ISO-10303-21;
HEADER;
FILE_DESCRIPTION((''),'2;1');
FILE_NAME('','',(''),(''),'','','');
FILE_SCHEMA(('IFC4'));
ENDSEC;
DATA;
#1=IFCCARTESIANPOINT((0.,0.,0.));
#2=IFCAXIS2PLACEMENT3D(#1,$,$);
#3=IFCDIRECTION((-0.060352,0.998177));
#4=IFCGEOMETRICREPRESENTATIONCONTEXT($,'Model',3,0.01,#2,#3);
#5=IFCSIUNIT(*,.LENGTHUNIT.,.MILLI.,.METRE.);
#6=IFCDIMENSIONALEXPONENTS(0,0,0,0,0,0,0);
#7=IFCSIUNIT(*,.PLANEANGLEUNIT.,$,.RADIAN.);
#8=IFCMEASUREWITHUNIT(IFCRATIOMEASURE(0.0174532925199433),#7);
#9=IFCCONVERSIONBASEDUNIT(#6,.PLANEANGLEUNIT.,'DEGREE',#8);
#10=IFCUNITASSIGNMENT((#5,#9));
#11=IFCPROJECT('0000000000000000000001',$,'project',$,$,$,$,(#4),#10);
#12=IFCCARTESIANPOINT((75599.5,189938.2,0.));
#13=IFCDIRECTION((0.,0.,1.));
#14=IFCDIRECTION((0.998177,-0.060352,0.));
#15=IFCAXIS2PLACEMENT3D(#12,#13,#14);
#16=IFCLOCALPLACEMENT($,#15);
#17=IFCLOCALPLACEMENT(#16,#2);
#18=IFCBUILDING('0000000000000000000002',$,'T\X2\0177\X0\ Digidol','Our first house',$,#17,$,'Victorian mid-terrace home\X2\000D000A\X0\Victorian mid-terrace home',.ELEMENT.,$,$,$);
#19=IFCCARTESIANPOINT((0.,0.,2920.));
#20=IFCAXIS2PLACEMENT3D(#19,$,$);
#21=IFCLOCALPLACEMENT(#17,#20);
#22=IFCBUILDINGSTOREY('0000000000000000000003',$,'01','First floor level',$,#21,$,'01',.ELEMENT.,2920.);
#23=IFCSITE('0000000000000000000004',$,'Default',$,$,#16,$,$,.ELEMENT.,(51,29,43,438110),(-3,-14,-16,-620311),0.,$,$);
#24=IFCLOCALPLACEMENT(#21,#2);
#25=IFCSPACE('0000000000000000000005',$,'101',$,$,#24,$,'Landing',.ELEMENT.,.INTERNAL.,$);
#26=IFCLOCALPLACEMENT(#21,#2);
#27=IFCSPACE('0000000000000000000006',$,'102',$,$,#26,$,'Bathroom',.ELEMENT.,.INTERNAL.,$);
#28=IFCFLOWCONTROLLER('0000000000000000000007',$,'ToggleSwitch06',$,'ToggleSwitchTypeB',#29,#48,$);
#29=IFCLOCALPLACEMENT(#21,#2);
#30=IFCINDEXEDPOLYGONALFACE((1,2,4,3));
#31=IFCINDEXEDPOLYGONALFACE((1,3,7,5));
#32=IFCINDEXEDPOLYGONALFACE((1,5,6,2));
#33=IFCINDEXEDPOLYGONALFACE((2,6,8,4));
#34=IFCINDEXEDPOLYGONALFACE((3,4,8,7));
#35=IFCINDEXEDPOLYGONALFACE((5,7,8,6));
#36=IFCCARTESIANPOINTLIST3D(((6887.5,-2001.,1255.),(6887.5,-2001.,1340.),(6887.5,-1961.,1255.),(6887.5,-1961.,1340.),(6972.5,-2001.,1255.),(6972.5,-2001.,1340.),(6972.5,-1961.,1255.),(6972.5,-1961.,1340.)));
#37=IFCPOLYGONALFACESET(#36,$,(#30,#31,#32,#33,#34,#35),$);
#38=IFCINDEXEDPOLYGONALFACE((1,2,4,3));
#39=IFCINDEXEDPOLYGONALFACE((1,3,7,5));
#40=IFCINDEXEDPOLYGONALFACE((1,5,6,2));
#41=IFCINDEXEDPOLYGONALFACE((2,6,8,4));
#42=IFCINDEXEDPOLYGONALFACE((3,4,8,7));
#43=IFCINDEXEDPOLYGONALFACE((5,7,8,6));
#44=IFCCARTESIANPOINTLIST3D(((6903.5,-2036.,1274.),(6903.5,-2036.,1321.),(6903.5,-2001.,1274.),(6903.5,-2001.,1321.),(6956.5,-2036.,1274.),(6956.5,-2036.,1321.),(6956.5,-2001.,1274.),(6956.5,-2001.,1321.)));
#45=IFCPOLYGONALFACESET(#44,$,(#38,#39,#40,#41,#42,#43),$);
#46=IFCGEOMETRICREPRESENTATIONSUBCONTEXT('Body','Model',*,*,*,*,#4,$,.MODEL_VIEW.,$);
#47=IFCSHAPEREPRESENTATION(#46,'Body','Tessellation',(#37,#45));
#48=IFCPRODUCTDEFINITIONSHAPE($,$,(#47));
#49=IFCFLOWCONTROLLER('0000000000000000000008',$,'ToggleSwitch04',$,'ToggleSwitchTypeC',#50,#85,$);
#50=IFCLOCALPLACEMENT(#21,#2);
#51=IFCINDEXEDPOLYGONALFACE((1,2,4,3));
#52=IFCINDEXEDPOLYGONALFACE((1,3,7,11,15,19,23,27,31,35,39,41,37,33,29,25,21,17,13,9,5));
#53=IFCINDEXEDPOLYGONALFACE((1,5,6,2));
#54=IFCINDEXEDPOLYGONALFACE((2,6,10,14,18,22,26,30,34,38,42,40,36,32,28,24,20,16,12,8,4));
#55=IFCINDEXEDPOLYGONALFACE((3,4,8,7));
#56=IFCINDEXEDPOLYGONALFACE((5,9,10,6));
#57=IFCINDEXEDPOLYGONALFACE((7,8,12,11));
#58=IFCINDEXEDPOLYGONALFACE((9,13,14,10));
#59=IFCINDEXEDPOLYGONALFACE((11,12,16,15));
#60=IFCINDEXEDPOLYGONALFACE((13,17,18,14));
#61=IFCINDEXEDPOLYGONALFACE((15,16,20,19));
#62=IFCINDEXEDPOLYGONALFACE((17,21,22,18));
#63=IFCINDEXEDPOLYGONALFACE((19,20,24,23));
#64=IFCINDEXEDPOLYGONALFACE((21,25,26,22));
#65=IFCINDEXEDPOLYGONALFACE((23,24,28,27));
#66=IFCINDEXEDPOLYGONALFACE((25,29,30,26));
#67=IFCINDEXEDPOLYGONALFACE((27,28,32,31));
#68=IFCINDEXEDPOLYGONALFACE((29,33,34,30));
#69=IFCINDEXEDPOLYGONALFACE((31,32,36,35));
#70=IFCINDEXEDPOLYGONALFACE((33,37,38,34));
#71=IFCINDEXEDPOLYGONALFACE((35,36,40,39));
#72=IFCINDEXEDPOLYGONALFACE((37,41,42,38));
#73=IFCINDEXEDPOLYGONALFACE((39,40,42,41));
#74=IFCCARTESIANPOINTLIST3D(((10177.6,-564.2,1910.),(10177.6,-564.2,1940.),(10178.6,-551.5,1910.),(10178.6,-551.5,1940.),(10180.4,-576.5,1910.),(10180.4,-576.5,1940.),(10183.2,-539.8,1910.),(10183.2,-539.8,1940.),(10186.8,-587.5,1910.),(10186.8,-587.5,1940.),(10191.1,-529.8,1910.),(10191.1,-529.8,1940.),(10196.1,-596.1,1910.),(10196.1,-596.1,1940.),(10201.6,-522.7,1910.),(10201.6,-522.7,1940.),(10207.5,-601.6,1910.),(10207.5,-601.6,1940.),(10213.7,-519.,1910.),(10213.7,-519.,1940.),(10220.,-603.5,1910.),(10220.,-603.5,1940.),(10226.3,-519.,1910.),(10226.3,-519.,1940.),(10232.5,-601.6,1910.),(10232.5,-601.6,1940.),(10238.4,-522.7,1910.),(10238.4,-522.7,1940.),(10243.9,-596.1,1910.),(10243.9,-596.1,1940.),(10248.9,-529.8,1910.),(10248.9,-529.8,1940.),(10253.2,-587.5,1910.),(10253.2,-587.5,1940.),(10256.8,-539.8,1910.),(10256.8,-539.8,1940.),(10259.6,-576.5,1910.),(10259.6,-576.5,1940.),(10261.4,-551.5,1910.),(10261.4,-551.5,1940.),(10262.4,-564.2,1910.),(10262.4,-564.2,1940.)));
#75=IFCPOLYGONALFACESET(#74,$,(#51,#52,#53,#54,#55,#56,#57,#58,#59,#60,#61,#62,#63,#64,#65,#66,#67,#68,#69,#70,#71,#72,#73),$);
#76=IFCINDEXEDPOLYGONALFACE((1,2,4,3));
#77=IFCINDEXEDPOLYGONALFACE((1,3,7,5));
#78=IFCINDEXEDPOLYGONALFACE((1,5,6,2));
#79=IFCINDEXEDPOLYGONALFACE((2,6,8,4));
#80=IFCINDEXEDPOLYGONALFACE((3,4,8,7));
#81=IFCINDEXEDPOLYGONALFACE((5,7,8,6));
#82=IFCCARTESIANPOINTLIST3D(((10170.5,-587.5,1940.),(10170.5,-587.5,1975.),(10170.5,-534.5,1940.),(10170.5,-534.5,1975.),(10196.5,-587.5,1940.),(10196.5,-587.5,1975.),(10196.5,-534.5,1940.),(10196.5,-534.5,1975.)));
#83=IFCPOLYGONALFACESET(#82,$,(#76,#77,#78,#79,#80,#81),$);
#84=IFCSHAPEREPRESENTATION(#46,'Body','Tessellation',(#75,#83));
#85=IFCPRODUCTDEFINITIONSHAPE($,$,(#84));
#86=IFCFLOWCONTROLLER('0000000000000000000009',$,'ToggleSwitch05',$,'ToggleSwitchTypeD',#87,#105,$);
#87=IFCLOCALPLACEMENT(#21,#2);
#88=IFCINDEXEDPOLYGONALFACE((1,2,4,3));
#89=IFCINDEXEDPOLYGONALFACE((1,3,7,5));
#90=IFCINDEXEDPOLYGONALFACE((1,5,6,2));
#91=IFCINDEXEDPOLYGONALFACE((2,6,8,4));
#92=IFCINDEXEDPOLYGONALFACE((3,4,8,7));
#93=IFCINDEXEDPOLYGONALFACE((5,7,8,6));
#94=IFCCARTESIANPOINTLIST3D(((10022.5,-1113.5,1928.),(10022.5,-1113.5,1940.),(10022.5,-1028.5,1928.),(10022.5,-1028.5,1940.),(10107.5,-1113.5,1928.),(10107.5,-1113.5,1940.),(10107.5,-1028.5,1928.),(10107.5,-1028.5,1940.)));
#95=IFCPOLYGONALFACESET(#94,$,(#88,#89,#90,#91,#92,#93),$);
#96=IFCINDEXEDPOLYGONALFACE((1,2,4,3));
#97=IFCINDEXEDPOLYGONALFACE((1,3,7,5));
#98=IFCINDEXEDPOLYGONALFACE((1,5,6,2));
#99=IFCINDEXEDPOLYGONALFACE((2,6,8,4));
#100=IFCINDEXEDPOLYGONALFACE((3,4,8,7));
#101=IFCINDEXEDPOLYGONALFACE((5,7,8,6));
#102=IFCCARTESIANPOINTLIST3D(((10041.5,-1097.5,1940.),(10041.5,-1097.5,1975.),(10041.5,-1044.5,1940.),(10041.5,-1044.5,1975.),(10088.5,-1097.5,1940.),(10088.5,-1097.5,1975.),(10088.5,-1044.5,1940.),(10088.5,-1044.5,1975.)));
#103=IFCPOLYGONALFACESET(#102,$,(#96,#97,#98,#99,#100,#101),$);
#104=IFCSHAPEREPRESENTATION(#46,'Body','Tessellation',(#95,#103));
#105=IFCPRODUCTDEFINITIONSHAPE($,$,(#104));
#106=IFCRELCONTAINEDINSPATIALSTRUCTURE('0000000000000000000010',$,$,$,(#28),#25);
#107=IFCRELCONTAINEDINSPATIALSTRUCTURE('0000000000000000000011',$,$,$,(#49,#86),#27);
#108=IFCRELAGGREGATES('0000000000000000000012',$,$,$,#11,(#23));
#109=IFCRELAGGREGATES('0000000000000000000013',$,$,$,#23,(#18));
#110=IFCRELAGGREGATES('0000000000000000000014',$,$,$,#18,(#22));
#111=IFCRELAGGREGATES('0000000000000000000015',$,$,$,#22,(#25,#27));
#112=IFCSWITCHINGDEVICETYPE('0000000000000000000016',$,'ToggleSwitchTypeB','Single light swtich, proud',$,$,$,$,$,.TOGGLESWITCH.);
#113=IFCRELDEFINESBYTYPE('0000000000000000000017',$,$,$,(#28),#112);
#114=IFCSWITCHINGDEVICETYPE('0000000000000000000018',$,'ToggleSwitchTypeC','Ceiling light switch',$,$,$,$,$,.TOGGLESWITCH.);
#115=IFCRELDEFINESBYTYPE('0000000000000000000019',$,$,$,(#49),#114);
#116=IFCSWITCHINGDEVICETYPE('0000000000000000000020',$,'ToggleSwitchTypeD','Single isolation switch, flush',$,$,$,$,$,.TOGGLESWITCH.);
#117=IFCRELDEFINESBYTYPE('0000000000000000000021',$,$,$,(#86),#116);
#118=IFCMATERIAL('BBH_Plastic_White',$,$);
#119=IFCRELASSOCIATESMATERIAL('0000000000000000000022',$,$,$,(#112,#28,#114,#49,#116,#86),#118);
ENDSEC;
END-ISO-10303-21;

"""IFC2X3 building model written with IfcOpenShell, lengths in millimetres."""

from ifc_helpers import new_model, entity, si_unit, converted_unit, direction, frame, frame_2d, origin, origin_2d_with_axis, place, context, subcontext, project, spatial, rectangle, circle, extrude, source, transform, mapped, material, type_object, type_shapes, element, save


model = new_model("IFC2X3")

# Units and contexts
model_context = context("Model", 3, precision=0.01, world=origin(), true_north=direction((-0.060352, 0.998177)))
body_context = subcontext(model_context, "Body", "Model", "MODEL_VIEW")
ifc_project = project(units=[si_unit("LENGTHUNIT", "METRE", prefix="MILLI"), converted_unit("PLANEANGLEUNIT", "DEGREE", entity("IfcRatioMeasure", 0.0174532925199433), si_unit("PLANEANGLEUNIT", "RADIAN"), dimensions=[0, 0, 0, 0, 0, 0, 0])], contexts=[model_context])

# Site, building, storey
site_placement = place(None, frame((75599.5, 189938.2, 0.0), z_axis=(0.0, 0.0, 1.0), x_axis=(0.998177, -0.060352, 0.0)))
site = spatial("IfcSite", under=ifc_project, at=site_placement, Name="Default", CompositionType="ELEMENT", RefLatitude=(51, 29, 43, 438110), RefLongitude=(-3, -14, -16, -620311), RefElevation=0.0)
building_placement = place(site_placement, origin())
building = spatial("IfcBuilding", under=site, at=building_placement, Name="Tŷ Digidol", Description="Our first house", LongName="Victorian mid-terrace home\r\nVictorian mid-terrace home", CompositionType="ELEMENT")
storey_placement = place(building_placement, frame((0.0, 0.0, 2920.0)))
storey = spatial("IfcBuildingStorey", under=building, at=storey_placement, Name="01", Description="First floor level", LongName="01", CompositionType="ELEMENT", Elevation=2920.0)

# Shared definitions
ifc_material = material(Name="BBH_Plastic_White")

# Shared definitions
space_1_placement = place(storey_placement, origin())
space_1 = spatial("IfcSpace", under=storey, at=space_1_placement, Name="101", LongName="Landing", CompositionType="ELEMENT", InteriorOrExteriorSpace="INTERNAL")

# Shared definitions
space_2_placement = place(storey_placement, origin())
space_2 = spatial("IfcSpace", under=storey, at=space_2_placement, Name="102", LongName="Bathroom", CompositionType="ELEMENT", InteriorOrExteriorSpace="INTERNAL")

# Flow controllers
switching_device_type_1 = type_object("IfcSwitchingDeviceType", Name="ToggleSwitchTypeB", Description="Single light swtich, proud", PredefinedType="TOGGLESWITCH", material=ifc_material)
shared_shape_1 = source(origin(), body_context, "Body", "SweptSolid", [
    extrude(rectangle(XDim=85.0, YDim=85.0, at=origin_2d_with_axis()), frame((0.0, -42.5, 0.0), z_axis=(0.0, 0.0, 1.0), x_axis=(0.0, 1.0, 0.0)), (0.0, 0.0, 1.0), 40.0),
    extrude(rectangle(XDim=47.0, YDim=53.0, at=origin_2d_with_axis()), frame((0.0, -42.5, -35.0), z_axis=(0.0, 0.0, 1.0), x_axis=(0.0, 1.0, 0.0)), (0.0, 0.0, 1.0), 35.0),
])
type_shapes(switching_device_type_1, [shared_shape_1])
flow_controller_1_placement = place(space_1_placement, frame((6930.0, -2001.0, 1340.0), z_axis=(0.0, 1.0, 0.0), x_axis=(-1.0, 0.0, 0.0)))
element("IfcFlowController", 1, at=flow_controller_1_placement, inside=space_1, type_object=switching_device_type_1, material=ifc_material, Name="ToggleSwitch06", ObjectType="ToggleSwitchTypeB", context=body_context, shape_type="MappedRepresentation", body=[
    mapped(shared_shape_1, transform((0.0, 0.0, 0.0), scale=1.0)),
])
switching_device_type_2 = type_object("IfcSwitchingDeviceType", Name="ToggleSwitchTypeC", Description="Ceiling light switch", PredefinedType="TOGGLESWITCH", material=ifc_material)
shared_shape_2 = source(origin(), body_context, "Body", "SweptSolid", [
    extrude(circle(Radius=42.5, at=frame_2d((0.0, 0.0), x_axis=(1.0, 0.0))), frame((0.0, -42.5, 0.0)), (0.0, 0.0, 1.0), 30.0),
    extrude(rectangle(XDim=26.0, YDim=53.0, at=origin_2d_with_axis()), frame((0.0, -6.0, -35.0), z_axis=(0.0, 0.0, 1.0), x_axis=(0.0, 1.0, 0.0)), (0.0, 0.0, 1.0), 35.0),
])
type_shapes(switching_device_type_2, [shared_shape_2])
flow_controller_2_placement = place(space_2_placement, frame((10177.5, -561.0, 1940.0), z_axis=(0.0, 0.0, -1.0), x_axis=(0.0, -1.0, 0.0)))
element("IfcFlowController", 2, at=flow_controller_2_placement, inside=space_2, type_object=switching_device_type_2, material=ifc_material, Name="ToggleSwitch04", ObjectType="ToggleSwitchTypeC", context=body_context, shape_type="MappedRepresentation", body=[
    mapped(shared_shape_2, transform((0.0, 0.0, 0.0), scale=1.0)),
])
switching_device_type_3 = type_object("IfcSwitchingDeviceType", Name="ToggleSwitchTypeD", Description="Single isolation switch, flush", PredefinedType="TOGGLESWITCH", material=ifc_material)
shared_shape_3 = source(origin(), body_context, "Body", "SweptSolid", [
    extrude(rectangle(XDim=85.0, YDim=85.0, at=origin_2d_with_axis()), frame((0.0, -42.5, 0.0), z_axis=(0.0, 0.0, 1.0), x_axis=(0.0, 1.0, 0.0)), (0.0, 0.0, 1.0), 12.0),
    extrude(rectangle(XDim=47.0, YDim=53.0, at=origin_2d_with_axis()), frame((0.0, -42.5, -35.0), z_axis=(0.0, 0.0, 1.0), x_axis=(0.0, 1.0, 0.0)), (0.0, 0.0, 1.0), 35.0),
])
type_shapes(switching_device_type_3, [shared_shape_3])
flow_controller_3_placement = place(space_2_placement, frame((10022.5, -1071.0, 1940.0), z_axis=(0.0, 0.0, -1.0), x_axis=(0.0, -1.0, 0.0)))
element("IfcFlowController", 3, at=flow_controller_3_placement, inside=space_2, type_object=switching_device_type_3, material=ifc_material, Name="ToggleSwitch05", ObjectType="ToggleSwitchTypeD", context=body_context, shape_type="MappedRepresentation", body=[
    mapped(shared_shape_3, transform((0.0, 0.0, 0.0), scale=1.0)),
])

save(model, "model.ifc")
